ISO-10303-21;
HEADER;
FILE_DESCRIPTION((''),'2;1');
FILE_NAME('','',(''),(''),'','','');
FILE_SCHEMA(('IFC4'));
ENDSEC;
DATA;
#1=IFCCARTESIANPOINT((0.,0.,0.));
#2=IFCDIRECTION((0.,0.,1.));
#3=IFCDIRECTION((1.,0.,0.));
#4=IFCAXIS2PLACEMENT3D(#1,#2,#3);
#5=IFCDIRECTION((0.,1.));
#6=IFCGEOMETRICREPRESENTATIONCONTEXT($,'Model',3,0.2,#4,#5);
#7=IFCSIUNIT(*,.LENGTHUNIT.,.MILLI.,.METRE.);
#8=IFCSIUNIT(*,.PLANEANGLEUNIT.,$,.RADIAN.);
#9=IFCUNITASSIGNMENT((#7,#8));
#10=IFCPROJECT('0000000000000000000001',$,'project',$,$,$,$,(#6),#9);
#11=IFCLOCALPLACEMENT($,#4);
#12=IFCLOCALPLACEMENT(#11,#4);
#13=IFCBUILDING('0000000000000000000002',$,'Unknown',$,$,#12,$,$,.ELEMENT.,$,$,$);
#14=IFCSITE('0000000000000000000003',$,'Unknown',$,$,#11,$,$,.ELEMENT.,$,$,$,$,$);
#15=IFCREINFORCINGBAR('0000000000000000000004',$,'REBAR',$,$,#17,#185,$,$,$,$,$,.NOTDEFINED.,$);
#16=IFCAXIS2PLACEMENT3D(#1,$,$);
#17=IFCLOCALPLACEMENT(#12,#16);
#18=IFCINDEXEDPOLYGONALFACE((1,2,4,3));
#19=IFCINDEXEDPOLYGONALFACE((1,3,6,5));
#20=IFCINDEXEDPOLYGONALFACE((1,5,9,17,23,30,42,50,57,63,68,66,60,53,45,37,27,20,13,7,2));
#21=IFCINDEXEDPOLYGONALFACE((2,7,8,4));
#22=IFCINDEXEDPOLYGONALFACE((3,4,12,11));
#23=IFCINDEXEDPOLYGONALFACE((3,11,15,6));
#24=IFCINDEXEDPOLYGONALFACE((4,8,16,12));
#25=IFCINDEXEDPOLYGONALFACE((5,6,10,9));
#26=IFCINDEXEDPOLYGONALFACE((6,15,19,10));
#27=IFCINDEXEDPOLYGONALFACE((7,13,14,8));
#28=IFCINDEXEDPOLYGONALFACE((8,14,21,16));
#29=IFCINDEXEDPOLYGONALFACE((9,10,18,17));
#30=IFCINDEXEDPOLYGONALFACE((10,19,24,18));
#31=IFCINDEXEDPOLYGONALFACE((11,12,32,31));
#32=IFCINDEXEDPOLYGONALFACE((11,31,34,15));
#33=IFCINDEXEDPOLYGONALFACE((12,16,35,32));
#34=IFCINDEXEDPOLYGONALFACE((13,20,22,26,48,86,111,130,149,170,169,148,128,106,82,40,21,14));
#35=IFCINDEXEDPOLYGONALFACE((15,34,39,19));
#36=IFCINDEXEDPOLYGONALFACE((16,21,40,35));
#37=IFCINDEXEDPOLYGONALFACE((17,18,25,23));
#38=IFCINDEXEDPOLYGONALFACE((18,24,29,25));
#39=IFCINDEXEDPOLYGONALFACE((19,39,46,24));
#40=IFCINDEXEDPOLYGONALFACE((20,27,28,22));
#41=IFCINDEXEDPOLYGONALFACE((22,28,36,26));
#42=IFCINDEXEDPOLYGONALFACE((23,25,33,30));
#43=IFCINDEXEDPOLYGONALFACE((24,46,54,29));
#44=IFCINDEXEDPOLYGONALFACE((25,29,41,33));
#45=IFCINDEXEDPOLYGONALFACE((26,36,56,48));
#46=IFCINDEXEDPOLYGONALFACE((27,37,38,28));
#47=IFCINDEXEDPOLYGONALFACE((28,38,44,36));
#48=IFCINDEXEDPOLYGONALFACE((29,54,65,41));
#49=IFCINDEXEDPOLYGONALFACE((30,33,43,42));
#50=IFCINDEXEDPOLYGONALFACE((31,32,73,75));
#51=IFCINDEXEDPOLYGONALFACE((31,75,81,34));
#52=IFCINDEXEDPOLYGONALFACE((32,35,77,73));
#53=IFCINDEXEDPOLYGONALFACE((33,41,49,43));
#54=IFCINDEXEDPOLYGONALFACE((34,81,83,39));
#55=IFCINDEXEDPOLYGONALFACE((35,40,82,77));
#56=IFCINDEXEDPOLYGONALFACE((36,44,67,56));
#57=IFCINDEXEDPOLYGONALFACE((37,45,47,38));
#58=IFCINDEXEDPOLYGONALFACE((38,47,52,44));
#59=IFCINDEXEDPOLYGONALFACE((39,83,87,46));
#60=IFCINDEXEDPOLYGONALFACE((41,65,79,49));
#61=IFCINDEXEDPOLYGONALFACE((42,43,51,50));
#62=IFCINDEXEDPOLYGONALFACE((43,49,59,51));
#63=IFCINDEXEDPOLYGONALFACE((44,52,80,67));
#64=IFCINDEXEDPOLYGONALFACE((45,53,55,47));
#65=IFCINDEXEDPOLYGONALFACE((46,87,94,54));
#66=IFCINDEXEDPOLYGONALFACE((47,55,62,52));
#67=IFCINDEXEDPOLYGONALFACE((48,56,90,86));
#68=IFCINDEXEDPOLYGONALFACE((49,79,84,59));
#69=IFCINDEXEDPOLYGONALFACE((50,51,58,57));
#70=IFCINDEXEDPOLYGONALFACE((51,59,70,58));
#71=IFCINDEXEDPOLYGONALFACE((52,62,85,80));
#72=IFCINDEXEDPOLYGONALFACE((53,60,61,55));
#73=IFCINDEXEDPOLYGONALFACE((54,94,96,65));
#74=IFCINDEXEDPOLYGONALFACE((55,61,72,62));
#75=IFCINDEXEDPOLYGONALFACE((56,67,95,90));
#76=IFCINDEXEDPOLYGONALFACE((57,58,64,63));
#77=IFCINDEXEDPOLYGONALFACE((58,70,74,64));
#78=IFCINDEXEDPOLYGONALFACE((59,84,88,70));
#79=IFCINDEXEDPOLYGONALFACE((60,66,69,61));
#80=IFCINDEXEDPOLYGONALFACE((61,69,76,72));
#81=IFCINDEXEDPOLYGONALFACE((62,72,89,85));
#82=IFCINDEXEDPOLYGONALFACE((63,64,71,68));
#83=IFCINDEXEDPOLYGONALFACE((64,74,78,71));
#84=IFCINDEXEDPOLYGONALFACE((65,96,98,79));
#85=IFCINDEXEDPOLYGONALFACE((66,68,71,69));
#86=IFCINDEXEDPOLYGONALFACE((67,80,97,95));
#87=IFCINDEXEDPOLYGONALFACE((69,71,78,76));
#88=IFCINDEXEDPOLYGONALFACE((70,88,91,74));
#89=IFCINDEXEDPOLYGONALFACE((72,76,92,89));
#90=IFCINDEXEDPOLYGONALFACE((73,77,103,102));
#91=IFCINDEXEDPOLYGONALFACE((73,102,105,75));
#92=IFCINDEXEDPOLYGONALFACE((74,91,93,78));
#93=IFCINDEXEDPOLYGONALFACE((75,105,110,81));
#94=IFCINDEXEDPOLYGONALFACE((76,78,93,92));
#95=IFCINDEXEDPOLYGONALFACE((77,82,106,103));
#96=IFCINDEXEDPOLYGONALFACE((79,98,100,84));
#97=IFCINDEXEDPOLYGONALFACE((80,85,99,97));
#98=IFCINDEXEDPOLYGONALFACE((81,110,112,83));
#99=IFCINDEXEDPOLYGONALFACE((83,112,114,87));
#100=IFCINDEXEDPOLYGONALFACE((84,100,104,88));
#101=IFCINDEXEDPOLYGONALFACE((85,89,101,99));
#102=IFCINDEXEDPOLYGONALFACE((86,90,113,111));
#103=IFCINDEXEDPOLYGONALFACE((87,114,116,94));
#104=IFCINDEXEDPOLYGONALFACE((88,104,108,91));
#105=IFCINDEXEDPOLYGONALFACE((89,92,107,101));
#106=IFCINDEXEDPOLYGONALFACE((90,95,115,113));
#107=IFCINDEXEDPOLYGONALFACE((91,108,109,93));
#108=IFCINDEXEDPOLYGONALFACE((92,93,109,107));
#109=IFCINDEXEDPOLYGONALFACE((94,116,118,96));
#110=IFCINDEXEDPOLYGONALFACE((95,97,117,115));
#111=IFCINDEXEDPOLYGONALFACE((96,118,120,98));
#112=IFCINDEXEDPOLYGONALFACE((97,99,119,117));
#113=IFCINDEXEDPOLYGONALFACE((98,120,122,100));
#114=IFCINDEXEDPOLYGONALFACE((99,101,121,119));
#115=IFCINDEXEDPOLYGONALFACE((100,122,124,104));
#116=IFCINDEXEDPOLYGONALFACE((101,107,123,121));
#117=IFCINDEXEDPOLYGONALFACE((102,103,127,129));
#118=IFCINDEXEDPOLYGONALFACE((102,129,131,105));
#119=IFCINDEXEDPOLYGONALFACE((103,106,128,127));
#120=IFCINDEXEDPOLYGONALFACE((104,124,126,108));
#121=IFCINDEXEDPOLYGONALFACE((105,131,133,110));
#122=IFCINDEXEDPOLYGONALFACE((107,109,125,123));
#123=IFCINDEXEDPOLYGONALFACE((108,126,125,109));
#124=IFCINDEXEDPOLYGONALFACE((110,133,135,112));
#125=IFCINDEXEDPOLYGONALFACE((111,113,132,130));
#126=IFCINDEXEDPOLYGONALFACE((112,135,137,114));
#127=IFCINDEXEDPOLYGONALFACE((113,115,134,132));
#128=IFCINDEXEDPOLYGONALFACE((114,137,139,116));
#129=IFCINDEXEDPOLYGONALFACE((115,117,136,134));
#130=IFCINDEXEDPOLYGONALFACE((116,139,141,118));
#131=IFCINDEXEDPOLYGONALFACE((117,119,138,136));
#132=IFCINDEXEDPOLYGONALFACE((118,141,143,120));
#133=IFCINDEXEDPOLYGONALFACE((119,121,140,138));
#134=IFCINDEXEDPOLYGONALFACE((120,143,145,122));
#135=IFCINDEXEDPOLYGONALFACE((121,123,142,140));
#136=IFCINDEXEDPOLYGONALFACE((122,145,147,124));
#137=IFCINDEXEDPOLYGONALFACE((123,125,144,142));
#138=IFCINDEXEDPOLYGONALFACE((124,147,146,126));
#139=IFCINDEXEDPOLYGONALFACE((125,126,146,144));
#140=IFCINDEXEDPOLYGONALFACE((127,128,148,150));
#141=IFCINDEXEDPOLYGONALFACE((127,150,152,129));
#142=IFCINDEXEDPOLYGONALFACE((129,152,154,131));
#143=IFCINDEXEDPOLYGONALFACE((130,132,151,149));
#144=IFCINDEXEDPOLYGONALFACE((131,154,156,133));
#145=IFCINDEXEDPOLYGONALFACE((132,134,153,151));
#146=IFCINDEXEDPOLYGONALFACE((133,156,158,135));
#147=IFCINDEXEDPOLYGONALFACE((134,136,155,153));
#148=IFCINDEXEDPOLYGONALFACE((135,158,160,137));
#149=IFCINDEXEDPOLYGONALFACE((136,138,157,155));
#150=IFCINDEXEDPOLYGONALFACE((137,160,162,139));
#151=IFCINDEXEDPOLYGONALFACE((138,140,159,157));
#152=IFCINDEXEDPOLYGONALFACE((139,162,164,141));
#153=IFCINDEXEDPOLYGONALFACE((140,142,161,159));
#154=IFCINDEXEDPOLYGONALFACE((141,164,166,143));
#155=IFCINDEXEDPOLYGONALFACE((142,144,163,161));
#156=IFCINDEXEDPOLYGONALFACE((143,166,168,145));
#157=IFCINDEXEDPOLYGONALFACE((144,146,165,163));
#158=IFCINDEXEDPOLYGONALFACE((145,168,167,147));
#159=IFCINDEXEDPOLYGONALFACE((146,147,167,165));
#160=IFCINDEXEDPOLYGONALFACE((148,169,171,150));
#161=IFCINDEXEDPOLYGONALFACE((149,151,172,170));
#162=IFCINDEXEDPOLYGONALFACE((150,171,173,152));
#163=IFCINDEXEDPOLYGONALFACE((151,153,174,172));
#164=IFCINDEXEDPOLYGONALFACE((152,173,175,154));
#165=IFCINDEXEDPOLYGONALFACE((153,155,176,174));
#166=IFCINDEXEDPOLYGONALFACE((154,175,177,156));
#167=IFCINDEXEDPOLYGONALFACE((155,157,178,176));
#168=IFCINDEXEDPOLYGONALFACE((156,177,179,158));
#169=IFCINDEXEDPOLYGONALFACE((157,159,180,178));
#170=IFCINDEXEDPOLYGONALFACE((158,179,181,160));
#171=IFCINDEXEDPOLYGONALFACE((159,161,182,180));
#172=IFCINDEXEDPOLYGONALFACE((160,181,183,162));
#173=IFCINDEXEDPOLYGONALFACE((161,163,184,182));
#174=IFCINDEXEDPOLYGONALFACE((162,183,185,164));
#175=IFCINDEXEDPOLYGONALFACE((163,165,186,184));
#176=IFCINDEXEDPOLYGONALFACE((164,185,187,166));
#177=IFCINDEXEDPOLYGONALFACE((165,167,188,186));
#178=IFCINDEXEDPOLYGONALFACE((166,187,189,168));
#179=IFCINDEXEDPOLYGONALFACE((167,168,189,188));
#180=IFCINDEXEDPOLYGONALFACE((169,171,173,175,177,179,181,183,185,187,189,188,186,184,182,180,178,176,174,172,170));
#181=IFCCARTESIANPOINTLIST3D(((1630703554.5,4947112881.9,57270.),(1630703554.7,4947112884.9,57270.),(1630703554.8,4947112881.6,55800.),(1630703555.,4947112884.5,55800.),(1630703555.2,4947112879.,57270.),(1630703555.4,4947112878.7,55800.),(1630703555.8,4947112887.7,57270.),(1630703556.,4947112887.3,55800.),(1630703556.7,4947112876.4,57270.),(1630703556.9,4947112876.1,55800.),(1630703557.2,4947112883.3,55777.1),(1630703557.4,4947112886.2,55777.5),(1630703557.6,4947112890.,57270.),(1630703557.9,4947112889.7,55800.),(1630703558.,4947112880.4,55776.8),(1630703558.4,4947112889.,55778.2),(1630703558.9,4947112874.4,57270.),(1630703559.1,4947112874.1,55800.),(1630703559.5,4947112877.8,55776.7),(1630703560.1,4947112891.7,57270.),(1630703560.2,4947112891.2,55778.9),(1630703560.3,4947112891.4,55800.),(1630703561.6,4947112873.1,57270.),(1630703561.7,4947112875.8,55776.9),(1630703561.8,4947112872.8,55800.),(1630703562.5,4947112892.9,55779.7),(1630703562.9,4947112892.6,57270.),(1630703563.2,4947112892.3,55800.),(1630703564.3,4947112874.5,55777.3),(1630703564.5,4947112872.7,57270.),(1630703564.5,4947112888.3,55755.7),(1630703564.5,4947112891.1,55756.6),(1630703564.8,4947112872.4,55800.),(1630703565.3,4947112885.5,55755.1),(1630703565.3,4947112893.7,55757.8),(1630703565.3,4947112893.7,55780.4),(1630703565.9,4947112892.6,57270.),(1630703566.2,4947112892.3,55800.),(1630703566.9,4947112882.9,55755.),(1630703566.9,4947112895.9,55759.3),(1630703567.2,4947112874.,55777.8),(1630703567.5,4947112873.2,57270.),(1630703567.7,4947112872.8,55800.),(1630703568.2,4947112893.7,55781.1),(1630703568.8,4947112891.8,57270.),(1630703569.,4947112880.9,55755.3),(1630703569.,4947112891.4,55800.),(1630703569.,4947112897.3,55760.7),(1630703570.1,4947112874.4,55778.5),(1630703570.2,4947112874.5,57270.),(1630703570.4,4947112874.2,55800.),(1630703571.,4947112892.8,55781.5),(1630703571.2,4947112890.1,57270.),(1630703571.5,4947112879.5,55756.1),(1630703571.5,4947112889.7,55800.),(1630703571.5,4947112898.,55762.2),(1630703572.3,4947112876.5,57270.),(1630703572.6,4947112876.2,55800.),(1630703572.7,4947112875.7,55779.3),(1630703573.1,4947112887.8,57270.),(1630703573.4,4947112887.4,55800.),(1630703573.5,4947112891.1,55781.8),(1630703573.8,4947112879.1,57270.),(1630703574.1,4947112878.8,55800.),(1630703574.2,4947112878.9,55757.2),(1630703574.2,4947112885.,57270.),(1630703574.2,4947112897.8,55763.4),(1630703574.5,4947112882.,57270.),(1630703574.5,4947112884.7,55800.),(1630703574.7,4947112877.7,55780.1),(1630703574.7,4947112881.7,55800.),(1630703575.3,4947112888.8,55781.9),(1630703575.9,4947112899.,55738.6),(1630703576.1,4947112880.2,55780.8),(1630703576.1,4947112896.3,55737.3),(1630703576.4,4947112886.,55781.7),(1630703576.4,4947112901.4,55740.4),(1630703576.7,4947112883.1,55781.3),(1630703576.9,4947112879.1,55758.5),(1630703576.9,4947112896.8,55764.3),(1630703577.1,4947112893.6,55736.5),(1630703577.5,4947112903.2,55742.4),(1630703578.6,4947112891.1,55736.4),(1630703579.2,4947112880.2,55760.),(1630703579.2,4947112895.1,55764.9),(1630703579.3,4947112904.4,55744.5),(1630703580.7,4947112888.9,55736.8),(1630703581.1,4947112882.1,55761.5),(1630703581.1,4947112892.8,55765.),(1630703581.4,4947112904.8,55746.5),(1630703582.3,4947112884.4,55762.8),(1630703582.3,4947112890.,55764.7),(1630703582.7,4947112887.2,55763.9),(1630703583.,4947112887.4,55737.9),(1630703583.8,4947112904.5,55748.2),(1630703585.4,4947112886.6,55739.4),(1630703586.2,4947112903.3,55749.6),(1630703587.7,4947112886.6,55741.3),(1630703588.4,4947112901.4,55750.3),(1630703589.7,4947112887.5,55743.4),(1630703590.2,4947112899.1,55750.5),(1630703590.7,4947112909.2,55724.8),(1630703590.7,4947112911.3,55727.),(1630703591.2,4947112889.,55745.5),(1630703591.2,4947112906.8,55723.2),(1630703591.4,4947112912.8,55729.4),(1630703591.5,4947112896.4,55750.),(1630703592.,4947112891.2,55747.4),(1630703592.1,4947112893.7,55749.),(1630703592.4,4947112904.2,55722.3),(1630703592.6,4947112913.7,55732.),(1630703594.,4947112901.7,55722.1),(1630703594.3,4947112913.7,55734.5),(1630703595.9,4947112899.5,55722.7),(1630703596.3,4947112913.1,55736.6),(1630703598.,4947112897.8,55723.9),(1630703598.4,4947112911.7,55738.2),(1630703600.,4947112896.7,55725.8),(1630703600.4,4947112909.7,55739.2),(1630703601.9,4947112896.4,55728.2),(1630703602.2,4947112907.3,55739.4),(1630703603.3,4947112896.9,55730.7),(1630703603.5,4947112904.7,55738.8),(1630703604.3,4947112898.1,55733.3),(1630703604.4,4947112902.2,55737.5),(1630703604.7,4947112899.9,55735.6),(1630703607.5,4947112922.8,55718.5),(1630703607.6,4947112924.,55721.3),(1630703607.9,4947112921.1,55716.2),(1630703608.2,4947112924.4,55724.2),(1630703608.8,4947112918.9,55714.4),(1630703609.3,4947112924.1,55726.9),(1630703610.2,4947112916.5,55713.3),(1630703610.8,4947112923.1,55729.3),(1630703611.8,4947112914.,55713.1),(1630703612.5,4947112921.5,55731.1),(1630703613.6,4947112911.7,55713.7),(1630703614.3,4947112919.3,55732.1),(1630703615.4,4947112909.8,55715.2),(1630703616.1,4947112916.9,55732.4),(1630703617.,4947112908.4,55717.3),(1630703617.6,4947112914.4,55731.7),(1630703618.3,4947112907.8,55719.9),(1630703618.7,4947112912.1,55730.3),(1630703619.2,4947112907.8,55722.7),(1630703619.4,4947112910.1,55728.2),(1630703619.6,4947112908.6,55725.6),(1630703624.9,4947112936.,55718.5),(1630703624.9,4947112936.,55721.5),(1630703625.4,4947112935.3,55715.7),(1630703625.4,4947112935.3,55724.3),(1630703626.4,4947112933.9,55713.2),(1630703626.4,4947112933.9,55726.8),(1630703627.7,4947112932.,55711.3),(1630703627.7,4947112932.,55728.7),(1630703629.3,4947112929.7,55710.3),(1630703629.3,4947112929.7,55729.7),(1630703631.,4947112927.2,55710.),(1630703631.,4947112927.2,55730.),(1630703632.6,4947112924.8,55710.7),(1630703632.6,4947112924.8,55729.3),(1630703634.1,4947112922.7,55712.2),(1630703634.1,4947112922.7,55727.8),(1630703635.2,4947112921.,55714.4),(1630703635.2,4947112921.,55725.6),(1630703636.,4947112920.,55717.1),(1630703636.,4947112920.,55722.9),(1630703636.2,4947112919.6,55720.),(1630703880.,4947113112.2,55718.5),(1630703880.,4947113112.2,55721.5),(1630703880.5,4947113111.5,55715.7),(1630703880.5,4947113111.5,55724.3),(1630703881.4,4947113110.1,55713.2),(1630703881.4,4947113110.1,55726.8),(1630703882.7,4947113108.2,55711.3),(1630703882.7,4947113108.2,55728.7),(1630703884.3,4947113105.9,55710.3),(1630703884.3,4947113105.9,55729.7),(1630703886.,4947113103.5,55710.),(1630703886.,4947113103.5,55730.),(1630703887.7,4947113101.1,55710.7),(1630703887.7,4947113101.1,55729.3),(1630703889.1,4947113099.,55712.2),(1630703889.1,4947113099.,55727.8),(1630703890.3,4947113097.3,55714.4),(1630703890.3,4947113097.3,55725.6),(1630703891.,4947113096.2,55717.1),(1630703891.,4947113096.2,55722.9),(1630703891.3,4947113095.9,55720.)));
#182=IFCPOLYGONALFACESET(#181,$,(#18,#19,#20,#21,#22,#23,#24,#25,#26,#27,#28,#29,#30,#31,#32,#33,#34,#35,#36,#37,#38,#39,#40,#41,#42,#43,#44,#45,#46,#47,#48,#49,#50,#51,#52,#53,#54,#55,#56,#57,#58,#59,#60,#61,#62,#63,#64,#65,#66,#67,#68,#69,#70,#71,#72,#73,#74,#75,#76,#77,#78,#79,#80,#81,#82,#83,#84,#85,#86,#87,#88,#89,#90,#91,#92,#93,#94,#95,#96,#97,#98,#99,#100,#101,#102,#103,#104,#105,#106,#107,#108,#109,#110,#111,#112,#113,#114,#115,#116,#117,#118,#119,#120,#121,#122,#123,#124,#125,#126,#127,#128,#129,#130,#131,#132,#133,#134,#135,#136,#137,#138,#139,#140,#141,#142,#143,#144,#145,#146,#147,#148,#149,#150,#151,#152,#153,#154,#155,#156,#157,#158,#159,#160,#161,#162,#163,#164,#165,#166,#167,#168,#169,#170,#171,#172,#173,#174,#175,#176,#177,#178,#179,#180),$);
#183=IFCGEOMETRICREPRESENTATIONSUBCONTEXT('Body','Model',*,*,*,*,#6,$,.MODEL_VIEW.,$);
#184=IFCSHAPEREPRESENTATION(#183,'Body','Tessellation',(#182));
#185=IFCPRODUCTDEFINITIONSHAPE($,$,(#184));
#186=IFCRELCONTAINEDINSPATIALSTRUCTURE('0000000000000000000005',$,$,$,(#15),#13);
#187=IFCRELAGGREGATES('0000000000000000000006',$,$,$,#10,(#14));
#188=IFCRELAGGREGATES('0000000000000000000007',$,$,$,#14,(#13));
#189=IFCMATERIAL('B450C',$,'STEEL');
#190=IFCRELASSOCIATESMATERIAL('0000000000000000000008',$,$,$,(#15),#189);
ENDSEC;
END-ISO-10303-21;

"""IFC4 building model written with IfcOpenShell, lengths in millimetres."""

from ifc_helpers import new_model, entity, si_unit, direction, frame, origin_with_axes, place, context, subcontext, project, spatial, material, element, save


model = new_model("IFC4")

# Units and contexts
model_context = context("Model", 3, precision=0.2, world=origin_with_axes(), true_north=direction((0.0, 1.0)))
body_context = subcontext(model_context, "Body", "Model", "MODEL_VIEW")
ifc_project = project(units=[si_unit("LENGTHUNIT", "METRE", prefix="MILLI"), si_unit("PLANEANGLEUNIT", "RADIAN")], contexts=[model_context])

# Site, building
site_placement = place(None, origin_with_axes())
site = spatial("IfcSite", under=ifc_project, at=site_placement, Name="Unknown", CompositionType="ELEMENT")
building_placement = place(site_placement, origin_with_axes())
building = spatial("IfcBuilding", under=site, at=building_placement, Name="Unknown", CompositionType="ELEMENT")

# Reinforcing bar
ifc_material = material(Name="B450C", Category="STEEL")
reinforcing_bar_1_placement = place(building_placement, frame((1630703495.2, 4947112895.0, 55670.0), z_axis=(0.568806, -0.822472, 0.0), x_axis=(0.0, 0.0, 1.0)))
element("IfcReinforcingBar", 1, at=reinforcing_bar_1_placement, inside=building, material=ifc_material, Name="REBAR", PredefinedType="NOTDEFINED", context=body_context, shape_type="AdvancedSweptSolid", body=[
    entity("IfcSweptDiskSolid", entity("IfcIndexedPolyCurve", entity("IfcCartesianPointList3D", [[50.0, -440.0, 50.1], [50.0, -130.0, 50.0], [73.4, -73.4, 50.0], [130.0, -50.0, 50.0], [1600.0, -50.0, 49.6]]), [entity("IfcLineIndex", [1, 2]), entity("IfcArcIndex", [2, 3, 4]), entity("IfcLineIndex", [4, 5])]), 10.0),
])

save(model, "model.ifc")
